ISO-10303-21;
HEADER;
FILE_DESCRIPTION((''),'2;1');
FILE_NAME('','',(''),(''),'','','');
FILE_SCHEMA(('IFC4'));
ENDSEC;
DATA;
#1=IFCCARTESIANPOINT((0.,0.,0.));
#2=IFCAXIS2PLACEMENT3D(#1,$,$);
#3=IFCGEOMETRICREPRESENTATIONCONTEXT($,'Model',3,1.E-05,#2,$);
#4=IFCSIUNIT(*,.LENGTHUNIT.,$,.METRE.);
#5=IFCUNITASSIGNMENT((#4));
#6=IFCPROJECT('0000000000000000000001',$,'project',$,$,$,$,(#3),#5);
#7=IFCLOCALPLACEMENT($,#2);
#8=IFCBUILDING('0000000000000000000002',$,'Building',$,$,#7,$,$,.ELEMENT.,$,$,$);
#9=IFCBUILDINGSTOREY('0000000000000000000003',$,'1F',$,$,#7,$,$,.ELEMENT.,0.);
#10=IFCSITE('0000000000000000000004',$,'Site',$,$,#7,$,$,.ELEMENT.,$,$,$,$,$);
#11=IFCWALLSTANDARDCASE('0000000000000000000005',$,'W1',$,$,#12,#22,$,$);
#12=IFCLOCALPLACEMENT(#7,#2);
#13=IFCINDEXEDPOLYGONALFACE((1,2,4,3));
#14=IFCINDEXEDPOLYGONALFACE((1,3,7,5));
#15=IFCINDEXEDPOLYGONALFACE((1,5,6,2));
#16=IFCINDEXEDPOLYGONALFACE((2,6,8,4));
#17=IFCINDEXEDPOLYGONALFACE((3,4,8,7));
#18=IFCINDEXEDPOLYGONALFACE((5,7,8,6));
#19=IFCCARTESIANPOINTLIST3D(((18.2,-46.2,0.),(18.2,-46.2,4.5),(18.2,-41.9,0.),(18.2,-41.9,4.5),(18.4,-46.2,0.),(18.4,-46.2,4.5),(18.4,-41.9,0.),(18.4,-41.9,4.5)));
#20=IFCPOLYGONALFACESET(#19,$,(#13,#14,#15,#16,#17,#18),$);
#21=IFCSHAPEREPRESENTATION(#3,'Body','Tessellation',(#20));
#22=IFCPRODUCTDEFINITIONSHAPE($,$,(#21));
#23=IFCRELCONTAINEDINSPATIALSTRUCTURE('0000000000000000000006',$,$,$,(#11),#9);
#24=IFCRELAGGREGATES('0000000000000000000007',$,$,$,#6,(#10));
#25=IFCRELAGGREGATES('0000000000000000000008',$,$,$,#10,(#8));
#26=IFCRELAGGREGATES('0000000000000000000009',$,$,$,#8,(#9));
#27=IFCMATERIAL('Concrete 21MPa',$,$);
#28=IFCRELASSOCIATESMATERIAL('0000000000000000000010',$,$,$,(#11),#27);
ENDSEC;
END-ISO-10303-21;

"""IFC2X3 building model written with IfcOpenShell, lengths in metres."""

from ifc_helpers import new_model, si_unit, frame, origin, origin_2d, place, context, project, spatial, rectangle, extrude, material, element, save


model = new_model("IFC2X3")

# Units and contexts
model_context = context("Model", 3, precision=1e-05, world=origin())
ifc_project = project(units=[si_unit("LENGTHUNIT", "METRE")], contexts=[model_context])

# Site, building, storey
placement = place(None, origin())
site = spatial("IfcSite", under=ifc_project, at=placement, Name="Site", CompositionType="ELEMENT")
building = spatial("IfcBuilding", under=site, at=placement, Name="Building", CompositionType="ELEMENT")
storey = spatial("IfcBuildingStorey", under=building, at=placement, Name="1F", CompositionType="ELEMENT", Elevation=0.0)

# Shared definitions
ifc_material_1 = material(Name="Concrete 21MPa")

# Wall
for number, where, name in (
    (1, (18.3, -44.05, 0.0), "W1"),
):
    element("IfcWallStandardCase", number, at=place(None, frame(where)), inside=storey, material=ifc_material_1, Name=name, context=model_context, shape_type="SweptSolid", body=[
        extrude(rectangle(XDim=0.2, YDim=4.3, at=origin_2d()), origin(), (0.0, 0.0, 1.0), 4.5),
    ])

save(model, "model.ifc")
